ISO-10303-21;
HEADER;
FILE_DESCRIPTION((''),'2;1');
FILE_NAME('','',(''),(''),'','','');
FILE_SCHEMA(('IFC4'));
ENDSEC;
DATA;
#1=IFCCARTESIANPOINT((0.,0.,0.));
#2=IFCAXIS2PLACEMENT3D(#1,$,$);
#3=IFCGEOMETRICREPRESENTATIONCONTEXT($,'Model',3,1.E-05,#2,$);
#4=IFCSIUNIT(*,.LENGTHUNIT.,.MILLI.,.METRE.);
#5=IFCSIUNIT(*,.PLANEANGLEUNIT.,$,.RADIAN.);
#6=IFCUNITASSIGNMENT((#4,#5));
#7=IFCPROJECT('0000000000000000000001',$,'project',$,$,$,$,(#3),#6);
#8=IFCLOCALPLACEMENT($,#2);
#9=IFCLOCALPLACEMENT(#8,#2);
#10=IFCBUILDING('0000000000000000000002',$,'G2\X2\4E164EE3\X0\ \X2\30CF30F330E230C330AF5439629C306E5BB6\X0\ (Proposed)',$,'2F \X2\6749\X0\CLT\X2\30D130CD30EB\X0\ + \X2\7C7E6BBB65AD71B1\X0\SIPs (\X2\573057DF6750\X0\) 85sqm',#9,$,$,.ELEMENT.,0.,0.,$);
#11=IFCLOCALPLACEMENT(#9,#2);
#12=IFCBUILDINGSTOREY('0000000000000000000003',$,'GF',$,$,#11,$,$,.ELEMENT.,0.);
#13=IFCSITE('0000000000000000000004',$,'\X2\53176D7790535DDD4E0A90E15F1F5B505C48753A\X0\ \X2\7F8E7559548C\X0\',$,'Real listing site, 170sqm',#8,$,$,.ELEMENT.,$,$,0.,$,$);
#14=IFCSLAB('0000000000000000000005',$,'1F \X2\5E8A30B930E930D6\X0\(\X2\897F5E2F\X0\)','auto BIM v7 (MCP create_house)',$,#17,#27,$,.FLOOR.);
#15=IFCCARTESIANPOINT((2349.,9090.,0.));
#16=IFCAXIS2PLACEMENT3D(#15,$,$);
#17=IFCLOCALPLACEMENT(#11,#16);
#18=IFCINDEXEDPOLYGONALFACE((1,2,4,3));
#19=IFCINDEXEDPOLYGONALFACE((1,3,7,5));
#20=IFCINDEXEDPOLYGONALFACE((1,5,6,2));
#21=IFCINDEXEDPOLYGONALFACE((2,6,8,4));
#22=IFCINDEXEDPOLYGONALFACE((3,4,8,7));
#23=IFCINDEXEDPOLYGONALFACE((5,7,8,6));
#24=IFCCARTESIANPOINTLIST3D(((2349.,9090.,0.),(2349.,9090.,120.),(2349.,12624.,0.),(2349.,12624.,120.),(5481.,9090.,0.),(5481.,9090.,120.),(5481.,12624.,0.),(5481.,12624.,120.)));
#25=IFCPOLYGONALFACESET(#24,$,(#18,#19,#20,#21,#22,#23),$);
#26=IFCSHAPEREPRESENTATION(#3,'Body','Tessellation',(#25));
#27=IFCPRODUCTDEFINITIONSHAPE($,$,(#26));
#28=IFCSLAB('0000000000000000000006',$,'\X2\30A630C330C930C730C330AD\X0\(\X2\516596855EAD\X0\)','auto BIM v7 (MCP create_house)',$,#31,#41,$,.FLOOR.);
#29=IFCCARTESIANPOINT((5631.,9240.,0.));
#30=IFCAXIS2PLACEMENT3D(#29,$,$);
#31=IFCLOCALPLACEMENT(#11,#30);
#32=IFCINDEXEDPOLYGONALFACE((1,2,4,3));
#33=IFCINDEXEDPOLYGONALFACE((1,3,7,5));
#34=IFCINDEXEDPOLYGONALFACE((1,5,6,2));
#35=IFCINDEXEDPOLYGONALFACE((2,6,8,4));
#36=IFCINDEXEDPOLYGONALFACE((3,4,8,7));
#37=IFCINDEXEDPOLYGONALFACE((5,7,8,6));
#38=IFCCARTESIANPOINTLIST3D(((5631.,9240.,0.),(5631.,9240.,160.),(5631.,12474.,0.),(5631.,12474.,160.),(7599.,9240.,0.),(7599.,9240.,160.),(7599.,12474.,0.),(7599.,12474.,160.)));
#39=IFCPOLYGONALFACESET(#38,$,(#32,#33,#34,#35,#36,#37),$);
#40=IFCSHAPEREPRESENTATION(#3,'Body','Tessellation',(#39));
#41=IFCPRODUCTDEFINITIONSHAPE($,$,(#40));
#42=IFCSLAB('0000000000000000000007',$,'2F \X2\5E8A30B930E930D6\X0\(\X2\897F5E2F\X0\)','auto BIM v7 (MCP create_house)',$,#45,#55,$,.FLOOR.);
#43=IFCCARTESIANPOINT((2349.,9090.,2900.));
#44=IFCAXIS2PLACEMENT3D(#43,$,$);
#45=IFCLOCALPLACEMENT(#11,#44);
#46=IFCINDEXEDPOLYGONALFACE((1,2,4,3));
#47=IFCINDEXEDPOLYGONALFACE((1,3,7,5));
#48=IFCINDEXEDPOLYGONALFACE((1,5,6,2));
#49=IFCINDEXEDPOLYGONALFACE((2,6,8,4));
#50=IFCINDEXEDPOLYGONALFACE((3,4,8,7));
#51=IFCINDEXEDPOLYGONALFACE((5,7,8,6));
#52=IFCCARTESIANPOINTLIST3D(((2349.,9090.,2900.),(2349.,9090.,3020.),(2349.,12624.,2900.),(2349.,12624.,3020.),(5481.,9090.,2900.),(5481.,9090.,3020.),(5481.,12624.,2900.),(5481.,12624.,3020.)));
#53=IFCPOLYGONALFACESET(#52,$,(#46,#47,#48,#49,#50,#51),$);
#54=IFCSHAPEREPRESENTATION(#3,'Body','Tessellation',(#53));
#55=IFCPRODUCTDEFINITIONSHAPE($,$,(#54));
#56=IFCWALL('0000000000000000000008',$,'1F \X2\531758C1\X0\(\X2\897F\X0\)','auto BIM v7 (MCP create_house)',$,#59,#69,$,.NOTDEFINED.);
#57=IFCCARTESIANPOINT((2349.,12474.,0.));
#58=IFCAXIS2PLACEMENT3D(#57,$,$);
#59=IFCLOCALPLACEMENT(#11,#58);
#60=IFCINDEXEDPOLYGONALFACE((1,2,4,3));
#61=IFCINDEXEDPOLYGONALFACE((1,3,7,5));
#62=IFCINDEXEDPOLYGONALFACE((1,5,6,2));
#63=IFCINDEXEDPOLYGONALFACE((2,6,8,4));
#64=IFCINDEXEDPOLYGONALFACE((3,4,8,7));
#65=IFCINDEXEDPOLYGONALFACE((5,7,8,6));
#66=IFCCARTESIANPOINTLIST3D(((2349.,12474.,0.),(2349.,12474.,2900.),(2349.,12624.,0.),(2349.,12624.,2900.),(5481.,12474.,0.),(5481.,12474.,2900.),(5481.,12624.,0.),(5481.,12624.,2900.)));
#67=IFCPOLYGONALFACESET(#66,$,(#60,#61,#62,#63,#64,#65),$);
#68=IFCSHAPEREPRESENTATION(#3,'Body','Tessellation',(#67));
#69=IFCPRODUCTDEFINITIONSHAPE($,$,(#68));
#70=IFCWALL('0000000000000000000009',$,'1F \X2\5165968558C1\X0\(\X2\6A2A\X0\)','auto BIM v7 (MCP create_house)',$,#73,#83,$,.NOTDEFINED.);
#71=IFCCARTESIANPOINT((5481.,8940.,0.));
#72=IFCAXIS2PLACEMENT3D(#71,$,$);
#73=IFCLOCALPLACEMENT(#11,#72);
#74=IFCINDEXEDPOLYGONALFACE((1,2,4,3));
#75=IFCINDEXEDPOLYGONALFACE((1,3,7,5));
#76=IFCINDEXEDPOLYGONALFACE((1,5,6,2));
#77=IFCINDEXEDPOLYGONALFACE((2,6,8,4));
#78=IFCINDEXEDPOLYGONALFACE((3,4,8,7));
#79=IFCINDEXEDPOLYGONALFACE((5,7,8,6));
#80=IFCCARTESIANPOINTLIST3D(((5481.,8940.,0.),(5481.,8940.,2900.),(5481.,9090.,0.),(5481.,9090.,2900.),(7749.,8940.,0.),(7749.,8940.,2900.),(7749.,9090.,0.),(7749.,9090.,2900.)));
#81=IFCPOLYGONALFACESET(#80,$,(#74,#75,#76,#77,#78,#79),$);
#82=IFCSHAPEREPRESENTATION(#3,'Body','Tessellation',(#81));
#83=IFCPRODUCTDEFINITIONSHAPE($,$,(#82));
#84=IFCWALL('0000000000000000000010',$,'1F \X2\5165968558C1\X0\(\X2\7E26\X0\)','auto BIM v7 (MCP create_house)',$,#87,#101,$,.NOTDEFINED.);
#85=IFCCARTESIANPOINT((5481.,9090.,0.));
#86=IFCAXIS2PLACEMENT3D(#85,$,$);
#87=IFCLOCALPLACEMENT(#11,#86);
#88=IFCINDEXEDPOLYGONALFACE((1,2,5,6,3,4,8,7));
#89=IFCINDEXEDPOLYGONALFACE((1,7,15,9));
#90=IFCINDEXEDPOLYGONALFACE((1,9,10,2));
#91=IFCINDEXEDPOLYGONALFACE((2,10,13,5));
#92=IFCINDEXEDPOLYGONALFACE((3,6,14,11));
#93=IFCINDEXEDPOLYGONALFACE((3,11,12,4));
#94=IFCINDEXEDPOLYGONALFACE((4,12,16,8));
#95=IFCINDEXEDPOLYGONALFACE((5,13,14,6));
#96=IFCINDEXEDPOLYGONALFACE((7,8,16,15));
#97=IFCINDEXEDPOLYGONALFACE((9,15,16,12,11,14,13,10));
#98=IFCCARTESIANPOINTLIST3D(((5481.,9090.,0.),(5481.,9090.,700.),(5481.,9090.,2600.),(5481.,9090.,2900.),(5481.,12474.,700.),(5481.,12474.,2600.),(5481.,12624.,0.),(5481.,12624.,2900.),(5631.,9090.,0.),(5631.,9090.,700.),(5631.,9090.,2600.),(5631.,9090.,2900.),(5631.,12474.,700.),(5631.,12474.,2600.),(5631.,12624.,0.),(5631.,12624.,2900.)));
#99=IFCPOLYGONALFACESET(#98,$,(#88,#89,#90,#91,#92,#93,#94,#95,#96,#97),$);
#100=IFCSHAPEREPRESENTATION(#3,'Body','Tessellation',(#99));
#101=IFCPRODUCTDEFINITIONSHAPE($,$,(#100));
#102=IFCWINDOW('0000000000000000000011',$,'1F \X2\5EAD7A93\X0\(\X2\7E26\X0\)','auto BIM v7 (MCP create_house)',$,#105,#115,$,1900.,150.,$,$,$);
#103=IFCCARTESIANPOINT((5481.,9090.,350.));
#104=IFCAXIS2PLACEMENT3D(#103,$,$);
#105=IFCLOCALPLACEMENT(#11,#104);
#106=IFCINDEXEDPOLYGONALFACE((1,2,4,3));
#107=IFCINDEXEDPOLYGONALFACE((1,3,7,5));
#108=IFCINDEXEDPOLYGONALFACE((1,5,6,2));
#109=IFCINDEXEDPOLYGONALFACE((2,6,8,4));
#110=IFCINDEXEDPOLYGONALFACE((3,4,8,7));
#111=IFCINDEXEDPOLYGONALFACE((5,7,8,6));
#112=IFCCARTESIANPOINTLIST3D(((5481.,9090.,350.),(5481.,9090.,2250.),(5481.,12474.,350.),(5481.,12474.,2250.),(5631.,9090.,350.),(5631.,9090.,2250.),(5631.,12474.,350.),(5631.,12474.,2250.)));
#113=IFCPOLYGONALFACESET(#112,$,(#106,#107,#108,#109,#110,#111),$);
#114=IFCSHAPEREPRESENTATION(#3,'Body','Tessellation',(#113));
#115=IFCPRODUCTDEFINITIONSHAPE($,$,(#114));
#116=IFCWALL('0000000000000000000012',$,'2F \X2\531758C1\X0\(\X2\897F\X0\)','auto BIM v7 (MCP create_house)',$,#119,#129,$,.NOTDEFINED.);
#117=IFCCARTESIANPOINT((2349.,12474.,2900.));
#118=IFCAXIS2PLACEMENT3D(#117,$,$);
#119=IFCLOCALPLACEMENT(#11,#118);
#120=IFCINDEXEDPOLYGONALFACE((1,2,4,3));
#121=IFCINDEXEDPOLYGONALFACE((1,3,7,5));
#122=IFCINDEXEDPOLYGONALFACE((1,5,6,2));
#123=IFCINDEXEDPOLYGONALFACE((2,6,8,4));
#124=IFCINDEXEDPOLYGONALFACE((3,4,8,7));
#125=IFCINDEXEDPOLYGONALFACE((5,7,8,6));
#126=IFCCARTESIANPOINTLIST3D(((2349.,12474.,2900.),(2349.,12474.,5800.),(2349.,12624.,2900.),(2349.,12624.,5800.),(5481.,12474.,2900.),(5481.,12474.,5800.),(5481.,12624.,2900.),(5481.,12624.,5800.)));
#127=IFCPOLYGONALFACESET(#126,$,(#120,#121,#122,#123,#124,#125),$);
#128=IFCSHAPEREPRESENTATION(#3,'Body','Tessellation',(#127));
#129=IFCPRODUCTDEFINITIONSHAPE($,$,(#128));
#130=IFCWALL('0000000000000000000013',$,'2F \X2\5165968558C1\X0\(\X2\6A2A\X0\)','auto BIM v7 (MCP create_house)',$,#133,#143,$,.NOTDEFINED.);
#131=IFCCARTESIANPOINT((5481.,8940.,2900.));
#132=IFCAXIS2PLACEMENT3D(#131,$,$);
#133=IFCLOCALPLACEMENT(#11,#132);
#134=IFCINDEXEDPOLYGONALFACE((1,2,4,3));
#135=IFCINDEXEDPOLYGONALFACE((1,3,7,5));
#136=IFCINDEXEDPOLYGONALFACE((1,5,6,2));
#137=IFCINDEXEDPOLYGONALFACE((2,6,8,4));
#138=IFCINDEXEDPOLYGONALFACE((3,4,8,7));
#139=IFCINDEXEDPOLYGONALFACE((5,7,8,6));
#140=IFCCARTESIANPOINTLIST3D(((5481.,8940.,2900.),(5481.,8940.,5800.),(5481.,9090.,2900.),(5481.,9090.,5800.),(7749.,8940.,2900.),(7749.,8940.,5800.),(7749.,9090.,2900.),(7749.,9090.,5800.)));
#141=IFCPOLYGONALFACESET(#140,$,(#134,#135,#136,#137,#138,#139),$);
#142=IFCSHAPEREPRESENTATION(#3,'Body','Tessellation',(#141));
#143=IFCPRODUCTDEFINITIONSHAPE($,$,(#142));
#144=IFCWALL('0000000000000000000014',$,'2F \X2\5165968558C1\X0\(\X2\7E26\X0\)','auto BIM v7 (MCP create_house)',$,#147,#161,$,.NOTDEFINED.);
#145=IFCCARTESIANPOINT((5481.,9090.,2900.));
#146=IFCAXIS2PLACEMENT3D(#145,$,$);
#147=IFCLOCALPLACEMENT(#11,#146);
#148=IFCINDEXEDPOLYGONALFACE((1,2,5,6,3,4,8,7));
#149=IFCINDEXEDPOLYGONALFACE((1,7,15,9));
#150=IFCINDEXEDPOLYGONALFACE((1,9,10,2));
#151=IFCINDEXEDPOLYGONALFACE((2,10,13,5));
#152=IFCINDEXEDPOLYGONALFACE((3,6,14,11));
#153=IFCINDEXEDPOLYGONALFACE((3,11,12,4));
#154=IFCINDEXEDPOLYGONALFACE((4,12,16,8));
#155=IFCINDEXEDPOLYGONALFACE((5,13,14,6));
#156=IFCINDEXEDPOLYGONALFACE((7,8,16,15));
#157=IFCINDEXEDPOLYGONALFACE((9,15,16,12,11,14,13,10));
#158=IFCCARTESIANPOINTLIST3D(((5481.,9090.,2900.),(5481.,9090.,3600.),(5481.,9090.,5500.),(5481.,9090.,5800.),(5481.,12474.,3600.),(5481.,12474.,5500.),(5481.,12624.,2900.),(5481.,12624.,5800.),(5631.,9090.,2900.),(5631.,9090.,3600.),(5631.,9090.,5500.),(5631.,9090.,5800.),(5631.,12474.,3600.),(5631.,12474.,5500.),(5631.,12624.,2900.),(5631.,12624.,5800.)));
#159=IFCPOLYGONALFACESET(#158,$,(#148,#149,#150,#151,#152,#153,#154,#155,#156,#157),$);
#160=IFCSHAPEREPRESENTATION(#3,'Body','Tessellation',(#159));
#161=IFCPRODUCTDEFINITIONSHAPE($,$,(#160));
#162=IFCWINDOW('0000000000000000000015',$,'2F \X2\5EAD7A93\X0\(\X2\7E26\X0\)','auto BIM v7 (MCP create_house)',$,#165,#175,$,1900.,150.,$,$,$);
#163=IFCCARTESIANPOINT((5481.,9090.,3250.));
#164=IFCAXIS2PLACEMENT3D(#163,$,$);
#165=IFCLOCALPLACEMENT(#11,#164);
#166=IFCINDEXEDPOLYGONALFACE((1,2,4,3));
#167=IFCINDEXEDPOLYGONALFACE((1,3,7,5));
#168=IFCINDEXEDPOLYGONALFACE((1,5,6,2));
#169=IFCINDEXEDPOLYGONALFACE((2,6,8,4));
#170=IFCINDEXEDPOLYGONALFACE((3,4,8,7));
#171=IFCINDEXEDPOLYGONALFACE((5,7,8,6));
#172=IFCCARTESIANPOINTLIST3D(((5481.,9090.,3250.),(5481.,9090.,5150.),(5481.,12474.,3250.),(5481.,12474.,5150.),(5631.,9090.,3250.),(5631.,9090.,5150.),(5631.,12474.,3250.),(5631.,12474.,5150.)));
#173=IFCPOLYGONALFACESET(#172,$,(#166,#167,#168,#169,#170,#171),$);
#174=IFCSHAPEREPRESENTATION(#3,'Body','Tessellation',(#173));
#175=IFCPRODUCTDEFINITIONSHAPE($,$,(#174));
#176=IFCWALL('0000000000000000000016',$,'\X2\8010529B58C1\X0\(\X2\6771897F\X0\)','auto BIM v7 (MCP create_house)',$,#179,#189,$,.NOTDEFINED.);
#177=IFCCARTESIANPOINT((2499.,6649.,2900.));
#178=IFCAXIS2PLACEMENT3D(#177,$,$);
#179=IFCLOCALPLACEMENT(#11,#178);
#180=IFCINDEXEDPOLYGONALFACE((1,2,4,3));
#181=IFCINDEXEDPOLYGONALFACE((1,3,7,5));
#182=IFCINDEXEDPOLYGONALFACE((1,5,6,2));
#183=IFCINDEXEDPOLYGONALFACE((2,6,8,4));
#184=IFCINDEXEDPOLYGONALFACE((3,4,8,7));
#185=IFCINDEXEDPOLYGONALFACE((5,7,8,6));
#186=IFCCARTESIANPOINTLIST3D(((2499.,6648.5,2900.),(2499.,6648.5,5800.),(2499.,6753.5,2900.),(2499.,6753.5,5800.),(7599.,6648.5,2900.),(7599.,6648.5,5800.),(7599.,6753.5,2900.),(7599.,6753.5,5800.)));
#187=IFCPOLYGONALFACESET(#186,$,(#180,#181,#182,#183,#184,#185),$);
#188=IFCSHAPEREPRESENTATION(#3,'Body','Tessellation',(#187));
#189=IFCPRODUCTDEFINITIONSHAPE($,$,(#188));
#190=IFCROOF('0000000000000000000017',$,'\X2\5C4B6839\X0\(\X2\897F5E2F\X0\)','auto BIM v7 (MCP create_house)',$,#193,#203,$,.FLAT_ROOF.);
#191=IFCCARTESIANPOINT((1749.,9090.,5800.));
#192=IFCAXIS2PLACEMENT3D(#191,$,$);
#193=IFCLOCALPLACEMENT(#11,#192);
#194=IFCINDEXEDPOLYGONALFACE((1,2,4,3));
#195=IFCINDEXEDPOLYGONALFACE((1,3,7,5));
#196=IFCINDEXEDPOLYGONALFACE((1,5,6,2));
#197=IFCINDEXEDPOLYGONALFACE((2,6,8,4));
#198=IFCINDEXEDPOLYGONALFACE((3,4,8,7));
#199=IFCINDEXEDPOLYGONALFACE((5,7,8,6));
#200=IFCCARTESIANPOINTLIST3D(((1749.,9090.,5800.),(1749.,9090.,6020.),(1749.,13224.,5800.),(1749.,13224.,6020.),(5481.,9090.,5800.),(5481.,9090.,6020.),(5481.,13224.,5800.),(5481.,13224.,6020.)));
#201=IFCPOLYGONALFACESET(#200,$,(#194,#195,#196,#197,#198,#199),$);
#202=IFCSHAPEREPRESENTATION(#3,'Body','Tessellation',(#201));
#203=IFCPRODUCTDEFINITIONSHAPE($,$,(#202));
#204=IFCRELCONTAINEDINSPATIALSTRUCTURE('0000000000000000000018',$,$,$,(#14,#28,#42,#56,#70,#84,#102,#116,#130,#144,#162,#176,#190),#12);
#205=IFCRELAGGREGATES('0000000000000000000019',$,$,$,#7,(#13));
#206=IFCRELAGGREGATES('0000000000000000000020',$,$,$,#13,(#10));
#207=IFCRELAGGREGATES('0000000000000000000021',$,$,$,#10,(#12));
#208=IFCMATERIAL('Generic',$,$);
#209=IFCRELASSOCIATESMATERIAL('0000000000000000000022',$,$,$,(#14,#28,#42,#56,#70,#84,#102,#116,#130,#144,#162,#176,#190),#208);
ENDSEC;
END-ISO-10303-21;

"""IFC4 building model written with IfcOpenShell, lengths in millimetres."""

from ifc_helpers import new_model, si_unit, frame, frame_2d, origin, place, context, project, spatial, rectangle, extrude, material, element, fill, save


model = new_model("IFC4")

# Units and contexts
model_context = context("Model", 3, precision=1e-05, world=origin())
ifc_project = project(units=[si_unit("LENGTHUNIT", "METRE", prefix="MILLI"), si_unit("PLANEANGLEUNIT", "RADIAN")], contexts=[model_context])

# Site, building, storey
site_placement = place(None, origin())
site = spatial("IfcSite", under=ifc_project, at=site_placement, Name="北海道川上郡弟子屈町 美留和", ObjectType="Real listing site, 170sqm", CompositionType="ELEMENT", RefElevation=0.0)
building_placement = place(site_placement, origin())
building = spatial("IfcBuilding", under=site, at=building_placement, Name="G2世代 ハンモック吹抜の家 (Proposed)", ObjectType="2F 杉CLTパネル + 籾殻断熱SIPs (地域材) 85sqm", CompositionType="ELEMENT", ElevationOfRefHeight=0.0, ElevationOfTerrain=0.0)
storey_placement = place(building_placement, origin())
storey = spatial("IfcBuildingStorey", under=building, at=storey_placement, Name="GF", CompositionType="ELEMENT", Elevation=0.0)

# Slabs
ifc_material = material(Name="Generic")
slab_1_placement = place(storey_placement, frame((2349.0, 9090.0, 0.0)))
element("IfcSlab", 1, at=slab_1_placement, inside=storey, material=ifc_material, Name="1F 床スラブ(西帯)", Description="auto BIM v7 (MCP create_house)", PredefinedType="FLOOR", context=model_context, shape_type="SweptSolid", body=[
    extrude(rectangle(XDim=3132.0, YDim=3534.0, at=frame_2d((1566.0, 1767.0))), frame((2349.0, 9090.0, 0.0)), (0.0, 0.0, 1.0), 120.0),
])
slab_2_placement = place(storey_placement, frame((5631.0, 9240.0, 0.0)))
element("IfcSlab", 2, at=slab_2_placement, inside=storey, material=ifc_material, Name="ウッドデッキ(入隅庭)", Description="auto BIM v7 (MCP create_house)", PredefinedType="FLOOR", context=model_context, shape_type="SweptSolid", body=[
    extrude(rectangle(XDim=1968.0, YDim=3234.0, at=frame_2d((984.0, 1617.0))), frame((5631.0, 9240.0, 0.0)), (0.0, 0.0, 1.0), 160.0),
])
slab_3_placement = place(storey_placement, frame((2349.0, 9090.0, 2900.0)))
element("IfcSlab", 3, at=slab_3_placement, inside=storey, material=ifc_material, Name="2F 床スラブ(西帯)", Description="auto BIM v7 (MCP create_house)", PredefinedType="FLOOR", context=model_context, shape_type="SweptSolid", body=[
    extrude(rectangle(XDim=3132.0, YDim=3534.0, at=frame_2d((1566.0, 1767.0))), frame((2349.0, 9090.0, 2900.0)), (0.0, 0.0, 1.0), 120.0),
])

# Walls
wall_1_placement = place(storey_placement, frame((2349.0, 12474.0, 0.0)))
element("IfcWall", 4, at=wall_1_placement, inside=storey, material=ifc_material, Name="1F 北壁(西)", Description="auto BIM v7 (MCP create_house)", PredefinedType="NOTDEFINED", context=model_context, shape_type="SweptSolid", body=[
    extrude(rectangle(XDim=3132.0, YDim=150.0, at=frame_2d((1566.0, 75.0))), frame((2349.0, 12474.0, 0.0)), (0.0, 0.0, 1.0), 2900.0),
])
wall_2_placement = place(storey_placement, frame((5481.0, 8940.0, 0.0)))
element("IfcWall", 5, at=wall_2_placement, inside=storey, material=ifc_material, Name="1F 入隅壁(横)", Description="auto BIM v7 (MCP create_house)", PredefinedType="NOTDEFINED", context=model_context, shape_type="SweptSolid", body=[
    extrude(rectangle(XDim=2268.0, YDim=150.0, at=frame_2d((1134.0, 75.0))), frame((5481.0, 8940.0, 0.0)), (0.0, 0.0, 1.0), 2900.0),
])

# Wall, opening, window
wall_3_placement = place(storey_placement, frame((5481.0, 9090.0, 0.0)))
wall_3 = element("IfcWall", 6, at=wall_3_placement, inside=storey, material=ifc_material, Name="1F 入隅壁(縦)", Description="auto BIM v7 (MCP create_house)", PredefinedType="NOTDEFINED", context=model_context, shape_type="SweptSolid", body=[
    extrude(rectangle(XDim=150.0, YDim=3534.0, at=frame_2d((75.0, 1767.0))), frame((5481.0, 9090.0, 0.0)), (0.0, 0.0, 1.0), 2900.0),
])
opening_1_placement = place(storey_placement, frame((5481.0, 9090.0, 350.0)))
opening_1 = element("IfcOpeningElement", 7, at=opening_1_placement, cuts=wall_3, PredefinedType="NOTDEFINED", context=model_context, shape_type="SweptSolid", body=[
    extrude(rectangle(XDim=150.0, YDim=3384.0, at=frame_2d((75.0, 1692.0))), frame((5481.0, 9090.0, 350.0)), (0.0, 0.0, 1.0), 1900.0),
])
window_1_placement = place(storey_placement, frame((5481.0, 9090.0, 350.0)))
window_1 = element("IfcWindow", 8, at=window_1_placement, inside=storey, material=ifc_material, Name="1F 庭窓(縦)", Description="auto BIM v7 (MCP create_house)", OverallHeight=1900.0, OverallWidth=150.0, context=model_context, shape_type="SweptSolid", body=[
    extrude(rectangle(XDim=150.0, YDim=3384.0, at=frame_2d((75.0, 1692.0))), frame((5481.0, 9090.0, 350.0)), (0.0, 0.0, 1.0), 1900.0),
])
fill(opening_1, window_1)

# Walls
wall_4_placement = place(storey_placement, frame((2349.0, 12474.0, 2900.0)))
element("IfcWall", 9, at=wall_4_placement, inside=storey, material=ifc_material, Name="2F 北壁(西)", Description="auto BIM v7 (MCP create_house)", PredefinedType="NOTDEFINED", context=model_context, shape_type="SweptSolid", body=[
    extrude(rectangle(XDim=3132.0, YDim=150.0, at=frame_2d((1566.0, 75.0))), frame((2349.0, 12474.0, 2900.0)), (0.0, 0.0, 1.0), 2900.0),
])
wall_5_placement = place(storey_placement, frame((5481.0, 8940.0, 2900.0)))
element("IfcWall", 10, at=wall_5_placement, inside=storey, material=ifc_material, Name="2F 入隅壁(横)", Description="auto BIM v7 (MCP create_house)", PredefinedType="NOTDEFINED", context=model_context, shape_type="SweptSolid", body=[
    extrude(rectangle(XDim=2268.0, YDim=150.0, at=frame_2d((1134.0, 75.0))), frame((5481.0, 8940.0, 2900.0)), (0.0, 0.0, 1.0), 2900.0),
])

# Wall, opening, window
wall_6_placement = place(storey_placement, frame((5481.0, 9090.0, 2900.0)))
wall_6 = element("IfcWall", 11, at=wall_6_placement, inside=storey, material=ifc_material, Name="2F 入隅壁(縦)", Description="auto BIM v7 (MCP create_house)", PredefinedType="NOTDEFINED", context=model_context, shape_type="SweptSolid", body=[
    extrude(rectangle(XDim=150.0, YDim=3534.0, at=frame_2d((75.0, 1767.0))), frame((5481.0, 9090.0, 2900.0)), (0.0, 0.0, 1.0), 2900.0),
])
opening_2_placement = place(storey_placement, frame((5481.0, 9090.0, 3250.0)))
opening_2 = element("IfcOpeningElement", 12, at=opening_2_placement, cuts=wall_6, PredefinedType="NOTDEFINED", context=model_context, shape_type="SweptSolid", body=[
    extrude(rectangle(XDim=150.0, YDim=3384.0, at=frame_2d((75.0, 1692.0))), frame((5481.0, 9090.0, 3250.0)), (0.0, 0.0, 1.0), 1900.0),
])
window_2_placement = place(storey_placement, frame((5481.0, 9090.0, 3250.0)))
window_2 = element("IfcWindow", 13, at=window_2_placement, inside=storey, material=ifc_material, Name="2F 庭窓(縦)", Description="auto BIM v7 (MCP create_house)", OverallHeight=1900.0, OverallWidth=150.0, context=model_context, shape_type="SweptSolid", body=[
    extrude(rectangle(XDim=150.0, YDim=3384.0, at=frame_2d((75.0, 1692.0))), frame((5481.0, 9090.0, 3250.0)), (0.0, 0.0, 1.0), 1900.0),
])
fill(opening_2, window_2)

# Wall
wall_7_placement = place(storey_placement, frame((2499.0, 6649.0, 2900.0)))
element("IfcWall", 14, at=wall_7_placement, inside=storey, material=ifc_material, Name="耐力壁(東西)", Description="auto BIM v7 (MCP create_house)", PredefinedType="NOTDEFINED", context=model_context, shape_type="SweptSolid", body=[
    extrude(rectangle(XDim=5100.0, YDim=105.0, at=frame_2d((2550.0, 52.0))), frame((2499.0, 6649.0, 2900.0)), (0.0, 0.0, 1.0), 2900.0),
])

# Roof
for number, where, name in (
    (15, (1749.0, 9090.0, 5800.0), "屋根(西帯)"),
):
    element("IfcRoof", number, at=place(storey_placement, frame(where)), inside=storey, material=ifc_material, Name=name, Description="auto BIM v7 (MCP create_house)", PredefinedType="FLAT_ROOF", context=model_context, shape_type="SweptSolid", body=[
        extrude(rectangle(XDim=3732.0, YDim=4134.0, at=frame_2d((1866.0, 2067.0))), frame((1749.0, 9090.0, 5800.0)), (0.0, 0.0, 1.0), 220.0),
    ])

save(model, "model.ifc")
